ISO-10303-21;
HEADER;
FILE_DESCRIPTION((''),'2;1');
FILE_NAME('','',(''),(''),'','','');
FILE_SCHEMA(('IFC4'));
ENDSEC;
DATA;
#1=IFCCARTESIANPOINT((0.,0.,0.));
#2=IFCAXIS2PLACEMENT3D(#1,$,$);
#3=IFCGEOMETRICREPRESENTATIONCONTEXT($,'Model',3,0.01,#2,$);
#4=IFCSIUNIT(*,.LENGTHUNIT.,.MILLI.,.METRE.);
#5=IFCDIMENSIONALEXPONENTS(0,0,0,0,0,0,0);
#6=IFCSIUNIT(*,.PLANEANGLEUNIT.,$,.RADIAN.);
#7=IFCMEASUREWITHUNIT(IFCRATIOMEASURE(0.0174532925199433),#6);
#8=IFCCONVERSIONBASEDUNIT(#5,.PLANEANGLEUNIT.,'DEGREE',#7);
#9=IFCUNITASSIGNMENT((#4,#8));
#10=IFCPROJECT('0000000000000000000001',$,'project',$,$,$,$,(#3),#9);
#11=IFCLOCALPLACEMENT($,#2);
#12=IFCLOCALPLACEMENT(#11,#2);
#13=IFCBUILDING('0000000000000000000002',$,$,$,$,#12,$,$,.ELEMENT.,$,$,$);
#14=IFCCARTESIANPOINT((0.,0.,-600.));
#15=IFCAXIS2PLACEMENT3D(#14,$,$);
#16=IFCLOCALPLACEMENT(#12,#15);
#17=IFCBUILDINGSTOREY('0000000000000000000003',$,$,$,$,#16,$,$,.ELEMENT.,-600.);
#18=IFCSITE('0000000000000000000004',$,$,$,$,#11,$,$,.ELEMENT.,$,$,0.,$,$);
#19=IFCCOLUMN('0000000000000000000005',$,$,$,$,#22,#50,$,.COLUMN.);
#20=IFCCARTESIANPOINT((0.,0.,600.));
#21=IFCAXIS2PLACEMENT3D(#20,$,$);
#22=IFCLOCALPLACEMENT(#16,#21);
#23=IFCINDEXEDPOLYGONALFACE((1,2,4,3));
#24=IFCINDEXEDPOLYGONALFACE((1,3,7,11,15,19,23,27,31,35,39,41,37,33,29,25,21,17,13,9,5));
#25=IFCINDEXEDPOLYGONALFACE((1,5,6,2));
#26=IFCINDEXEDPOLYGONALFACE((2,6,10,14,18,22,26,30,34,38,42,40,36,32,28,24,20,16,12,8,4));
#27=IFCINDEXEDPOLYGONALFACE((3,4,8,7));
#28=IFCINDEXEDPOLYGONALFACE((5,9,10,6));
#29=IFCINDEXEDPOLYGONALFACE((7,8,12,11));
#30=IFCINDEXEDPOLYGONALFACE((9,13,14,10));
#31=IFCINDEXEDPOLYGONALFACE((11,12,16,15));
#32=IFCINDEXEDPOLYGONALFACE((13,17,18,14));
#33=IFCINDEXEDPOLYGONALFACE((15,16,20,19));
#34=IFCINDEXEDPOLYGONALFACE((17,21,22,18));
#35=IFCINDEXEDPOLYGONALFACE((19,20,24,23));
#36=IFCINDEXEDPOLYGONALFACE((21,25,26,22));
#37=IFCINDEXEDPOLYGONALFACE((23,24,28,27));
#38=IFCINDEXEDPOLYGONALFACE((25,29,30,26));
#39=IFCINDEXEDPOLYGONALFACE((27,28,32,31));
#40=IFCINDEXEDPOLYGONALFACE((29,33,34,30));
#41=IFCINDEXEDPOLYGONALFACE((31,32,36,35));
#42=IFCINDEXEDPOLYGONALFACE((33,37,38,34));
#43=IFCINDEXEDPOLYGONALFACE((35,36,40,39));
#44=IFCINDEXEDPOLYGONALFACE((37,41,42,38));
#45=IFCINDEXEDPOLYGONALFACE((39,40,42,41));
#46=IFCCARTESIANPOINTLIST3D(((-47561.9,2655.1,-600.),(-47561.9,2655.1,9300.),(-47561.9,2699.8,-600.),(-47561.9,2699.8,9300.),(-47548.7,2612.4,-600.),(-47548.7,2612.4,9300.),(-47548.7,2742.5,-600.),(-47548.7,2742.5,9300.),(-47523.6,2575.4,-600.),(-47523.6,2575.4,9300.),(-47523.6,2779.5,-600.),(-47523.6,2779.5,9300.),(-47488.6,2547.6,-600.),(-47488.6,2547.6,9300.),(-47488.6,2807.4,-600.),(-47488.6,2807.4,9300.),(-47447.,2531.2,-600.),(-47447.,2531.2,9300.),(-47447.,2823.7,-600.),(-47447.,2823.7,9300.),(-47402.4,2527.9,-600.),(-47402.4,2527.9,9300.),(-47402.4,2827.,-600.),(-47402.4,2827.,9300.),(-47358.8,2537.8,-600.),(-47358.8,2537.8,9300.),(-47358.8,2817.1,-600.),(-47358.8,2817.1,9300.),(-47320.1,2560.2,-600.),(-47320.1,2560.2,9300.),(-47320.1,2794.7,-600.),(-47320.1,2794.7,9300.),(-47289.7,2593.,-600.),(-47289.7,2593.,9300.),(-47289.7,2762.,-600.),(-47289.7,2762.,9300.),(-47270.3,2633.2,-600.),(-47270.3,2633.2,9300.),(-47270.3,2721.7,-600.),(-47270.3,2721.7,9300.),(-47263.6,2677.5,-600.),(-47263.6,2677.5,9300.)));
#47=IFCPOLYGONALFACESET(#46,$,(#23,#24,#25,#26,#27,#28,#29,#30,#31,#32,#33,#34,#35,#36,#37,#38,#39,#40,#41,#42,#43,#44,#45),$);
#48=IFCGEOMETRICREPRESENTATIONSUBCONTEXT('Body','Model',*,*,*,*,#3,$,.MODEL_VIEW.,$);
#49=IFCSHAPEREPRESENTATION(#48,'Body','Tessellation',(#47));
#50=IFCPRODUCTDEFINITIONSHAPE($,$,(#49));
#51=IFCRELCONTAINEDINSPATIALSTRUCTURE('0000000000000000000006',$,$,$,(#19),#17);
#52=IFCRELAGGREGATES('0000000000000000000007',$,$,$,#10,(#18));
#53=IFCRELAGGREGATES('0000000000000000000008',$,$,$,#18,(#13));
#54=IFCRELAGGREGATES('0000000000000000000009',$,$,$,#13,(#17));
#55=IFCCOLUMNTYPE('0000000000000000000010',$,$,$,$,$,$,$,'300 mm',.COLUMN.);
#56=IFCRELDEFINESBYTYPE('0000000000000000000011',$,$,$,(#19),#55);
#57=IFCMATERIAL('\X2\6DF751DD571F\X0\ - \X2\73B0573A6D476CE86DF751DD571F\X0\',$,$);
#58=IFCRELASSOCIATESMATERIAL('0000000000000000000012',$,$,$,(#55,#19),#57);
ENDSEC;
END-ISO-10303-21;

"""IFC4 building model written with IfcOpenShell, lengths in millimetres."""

from ifc_helpers import new_model, entity, si_unit, converted_unit, frame, frame_2d, origin, place, context, subcontext, project, spatial, circle, extrude, source, transform, mapped, material, type_object, type_shapes, element, save


model = new_model("IFC4")

# Units and contexts
model_context = context("Model", 3, precision=0.01, world=origin())
body_context = subcontext(model_context, "Body", "Model", "MODEL_VIEW")
ifc_project = project(units=[si_unit("LENGTHUNIT", "METRE", prefix="MILLI"), converted_unit("PLANEANGLEUNIT", "DEGREE", entity("IfcRatioMeasure", 0.0174532925199433), si_unit("PLANEANGLEUNIT", "RADIAN"), dimensions=[0, 0, 0, 0, 0, 0, 0])], contexts=[model_context])

# Site, building, storey
site_placement = place(None, origin())
site = spatial("IfcSite", under=ifc_project, at=site_placement, CompositionType="ELEMENT", RefElevation=0.0)
building_placement = place(site_placement, origin())
building = spatial("IfcBuilding", under=site, at=building_placement, CompositionType="ELEMENT")
storey_placement = place(building_placement, frame((0.0, 0.0, -600.0)))
storey = spatial("IfcBuildingStorey", under=building, at=storey_placement, CompositionType="ELEMENT", Elevation=-600.0)

# Column
ifc_material_1 = material(Name="混凝土 - 现场浇注混凝土")
column_type_1 = type_object("IfcColumnType", ElementType="300 mm", PredefinedType="COLUMN", material=ifc_material_1)
shared_shape_1 = source(origin(), body_context, "Body", "SweptSolid", [
    extrude(circle(Radius=150.0, at=frame_2d((0.0, 0.0), x_axis=(1.0, 0.0))), frame((-47413.6, 2677.5, -600.0)), (0.0, 0.0, 1.0), 9900.0),
])
type_shapes(column_type_1, [shared_shape_1])
column_1_placement = place(storey_placement, frame((0.0, 0.0, 600.0)))
element("IfcColumn", 1, at=column_1_placement, inside=storey, type_object=column_type_1, material=ifc_material_1, PredefinedType="COLUMN", context=body_context, shape_type="MappedRepresentation", body=[
    mapped(shared_shape_1, transform((0.0, 0.0, 0.0), scale=1.0)),
])

save(model, "model.ifc")
